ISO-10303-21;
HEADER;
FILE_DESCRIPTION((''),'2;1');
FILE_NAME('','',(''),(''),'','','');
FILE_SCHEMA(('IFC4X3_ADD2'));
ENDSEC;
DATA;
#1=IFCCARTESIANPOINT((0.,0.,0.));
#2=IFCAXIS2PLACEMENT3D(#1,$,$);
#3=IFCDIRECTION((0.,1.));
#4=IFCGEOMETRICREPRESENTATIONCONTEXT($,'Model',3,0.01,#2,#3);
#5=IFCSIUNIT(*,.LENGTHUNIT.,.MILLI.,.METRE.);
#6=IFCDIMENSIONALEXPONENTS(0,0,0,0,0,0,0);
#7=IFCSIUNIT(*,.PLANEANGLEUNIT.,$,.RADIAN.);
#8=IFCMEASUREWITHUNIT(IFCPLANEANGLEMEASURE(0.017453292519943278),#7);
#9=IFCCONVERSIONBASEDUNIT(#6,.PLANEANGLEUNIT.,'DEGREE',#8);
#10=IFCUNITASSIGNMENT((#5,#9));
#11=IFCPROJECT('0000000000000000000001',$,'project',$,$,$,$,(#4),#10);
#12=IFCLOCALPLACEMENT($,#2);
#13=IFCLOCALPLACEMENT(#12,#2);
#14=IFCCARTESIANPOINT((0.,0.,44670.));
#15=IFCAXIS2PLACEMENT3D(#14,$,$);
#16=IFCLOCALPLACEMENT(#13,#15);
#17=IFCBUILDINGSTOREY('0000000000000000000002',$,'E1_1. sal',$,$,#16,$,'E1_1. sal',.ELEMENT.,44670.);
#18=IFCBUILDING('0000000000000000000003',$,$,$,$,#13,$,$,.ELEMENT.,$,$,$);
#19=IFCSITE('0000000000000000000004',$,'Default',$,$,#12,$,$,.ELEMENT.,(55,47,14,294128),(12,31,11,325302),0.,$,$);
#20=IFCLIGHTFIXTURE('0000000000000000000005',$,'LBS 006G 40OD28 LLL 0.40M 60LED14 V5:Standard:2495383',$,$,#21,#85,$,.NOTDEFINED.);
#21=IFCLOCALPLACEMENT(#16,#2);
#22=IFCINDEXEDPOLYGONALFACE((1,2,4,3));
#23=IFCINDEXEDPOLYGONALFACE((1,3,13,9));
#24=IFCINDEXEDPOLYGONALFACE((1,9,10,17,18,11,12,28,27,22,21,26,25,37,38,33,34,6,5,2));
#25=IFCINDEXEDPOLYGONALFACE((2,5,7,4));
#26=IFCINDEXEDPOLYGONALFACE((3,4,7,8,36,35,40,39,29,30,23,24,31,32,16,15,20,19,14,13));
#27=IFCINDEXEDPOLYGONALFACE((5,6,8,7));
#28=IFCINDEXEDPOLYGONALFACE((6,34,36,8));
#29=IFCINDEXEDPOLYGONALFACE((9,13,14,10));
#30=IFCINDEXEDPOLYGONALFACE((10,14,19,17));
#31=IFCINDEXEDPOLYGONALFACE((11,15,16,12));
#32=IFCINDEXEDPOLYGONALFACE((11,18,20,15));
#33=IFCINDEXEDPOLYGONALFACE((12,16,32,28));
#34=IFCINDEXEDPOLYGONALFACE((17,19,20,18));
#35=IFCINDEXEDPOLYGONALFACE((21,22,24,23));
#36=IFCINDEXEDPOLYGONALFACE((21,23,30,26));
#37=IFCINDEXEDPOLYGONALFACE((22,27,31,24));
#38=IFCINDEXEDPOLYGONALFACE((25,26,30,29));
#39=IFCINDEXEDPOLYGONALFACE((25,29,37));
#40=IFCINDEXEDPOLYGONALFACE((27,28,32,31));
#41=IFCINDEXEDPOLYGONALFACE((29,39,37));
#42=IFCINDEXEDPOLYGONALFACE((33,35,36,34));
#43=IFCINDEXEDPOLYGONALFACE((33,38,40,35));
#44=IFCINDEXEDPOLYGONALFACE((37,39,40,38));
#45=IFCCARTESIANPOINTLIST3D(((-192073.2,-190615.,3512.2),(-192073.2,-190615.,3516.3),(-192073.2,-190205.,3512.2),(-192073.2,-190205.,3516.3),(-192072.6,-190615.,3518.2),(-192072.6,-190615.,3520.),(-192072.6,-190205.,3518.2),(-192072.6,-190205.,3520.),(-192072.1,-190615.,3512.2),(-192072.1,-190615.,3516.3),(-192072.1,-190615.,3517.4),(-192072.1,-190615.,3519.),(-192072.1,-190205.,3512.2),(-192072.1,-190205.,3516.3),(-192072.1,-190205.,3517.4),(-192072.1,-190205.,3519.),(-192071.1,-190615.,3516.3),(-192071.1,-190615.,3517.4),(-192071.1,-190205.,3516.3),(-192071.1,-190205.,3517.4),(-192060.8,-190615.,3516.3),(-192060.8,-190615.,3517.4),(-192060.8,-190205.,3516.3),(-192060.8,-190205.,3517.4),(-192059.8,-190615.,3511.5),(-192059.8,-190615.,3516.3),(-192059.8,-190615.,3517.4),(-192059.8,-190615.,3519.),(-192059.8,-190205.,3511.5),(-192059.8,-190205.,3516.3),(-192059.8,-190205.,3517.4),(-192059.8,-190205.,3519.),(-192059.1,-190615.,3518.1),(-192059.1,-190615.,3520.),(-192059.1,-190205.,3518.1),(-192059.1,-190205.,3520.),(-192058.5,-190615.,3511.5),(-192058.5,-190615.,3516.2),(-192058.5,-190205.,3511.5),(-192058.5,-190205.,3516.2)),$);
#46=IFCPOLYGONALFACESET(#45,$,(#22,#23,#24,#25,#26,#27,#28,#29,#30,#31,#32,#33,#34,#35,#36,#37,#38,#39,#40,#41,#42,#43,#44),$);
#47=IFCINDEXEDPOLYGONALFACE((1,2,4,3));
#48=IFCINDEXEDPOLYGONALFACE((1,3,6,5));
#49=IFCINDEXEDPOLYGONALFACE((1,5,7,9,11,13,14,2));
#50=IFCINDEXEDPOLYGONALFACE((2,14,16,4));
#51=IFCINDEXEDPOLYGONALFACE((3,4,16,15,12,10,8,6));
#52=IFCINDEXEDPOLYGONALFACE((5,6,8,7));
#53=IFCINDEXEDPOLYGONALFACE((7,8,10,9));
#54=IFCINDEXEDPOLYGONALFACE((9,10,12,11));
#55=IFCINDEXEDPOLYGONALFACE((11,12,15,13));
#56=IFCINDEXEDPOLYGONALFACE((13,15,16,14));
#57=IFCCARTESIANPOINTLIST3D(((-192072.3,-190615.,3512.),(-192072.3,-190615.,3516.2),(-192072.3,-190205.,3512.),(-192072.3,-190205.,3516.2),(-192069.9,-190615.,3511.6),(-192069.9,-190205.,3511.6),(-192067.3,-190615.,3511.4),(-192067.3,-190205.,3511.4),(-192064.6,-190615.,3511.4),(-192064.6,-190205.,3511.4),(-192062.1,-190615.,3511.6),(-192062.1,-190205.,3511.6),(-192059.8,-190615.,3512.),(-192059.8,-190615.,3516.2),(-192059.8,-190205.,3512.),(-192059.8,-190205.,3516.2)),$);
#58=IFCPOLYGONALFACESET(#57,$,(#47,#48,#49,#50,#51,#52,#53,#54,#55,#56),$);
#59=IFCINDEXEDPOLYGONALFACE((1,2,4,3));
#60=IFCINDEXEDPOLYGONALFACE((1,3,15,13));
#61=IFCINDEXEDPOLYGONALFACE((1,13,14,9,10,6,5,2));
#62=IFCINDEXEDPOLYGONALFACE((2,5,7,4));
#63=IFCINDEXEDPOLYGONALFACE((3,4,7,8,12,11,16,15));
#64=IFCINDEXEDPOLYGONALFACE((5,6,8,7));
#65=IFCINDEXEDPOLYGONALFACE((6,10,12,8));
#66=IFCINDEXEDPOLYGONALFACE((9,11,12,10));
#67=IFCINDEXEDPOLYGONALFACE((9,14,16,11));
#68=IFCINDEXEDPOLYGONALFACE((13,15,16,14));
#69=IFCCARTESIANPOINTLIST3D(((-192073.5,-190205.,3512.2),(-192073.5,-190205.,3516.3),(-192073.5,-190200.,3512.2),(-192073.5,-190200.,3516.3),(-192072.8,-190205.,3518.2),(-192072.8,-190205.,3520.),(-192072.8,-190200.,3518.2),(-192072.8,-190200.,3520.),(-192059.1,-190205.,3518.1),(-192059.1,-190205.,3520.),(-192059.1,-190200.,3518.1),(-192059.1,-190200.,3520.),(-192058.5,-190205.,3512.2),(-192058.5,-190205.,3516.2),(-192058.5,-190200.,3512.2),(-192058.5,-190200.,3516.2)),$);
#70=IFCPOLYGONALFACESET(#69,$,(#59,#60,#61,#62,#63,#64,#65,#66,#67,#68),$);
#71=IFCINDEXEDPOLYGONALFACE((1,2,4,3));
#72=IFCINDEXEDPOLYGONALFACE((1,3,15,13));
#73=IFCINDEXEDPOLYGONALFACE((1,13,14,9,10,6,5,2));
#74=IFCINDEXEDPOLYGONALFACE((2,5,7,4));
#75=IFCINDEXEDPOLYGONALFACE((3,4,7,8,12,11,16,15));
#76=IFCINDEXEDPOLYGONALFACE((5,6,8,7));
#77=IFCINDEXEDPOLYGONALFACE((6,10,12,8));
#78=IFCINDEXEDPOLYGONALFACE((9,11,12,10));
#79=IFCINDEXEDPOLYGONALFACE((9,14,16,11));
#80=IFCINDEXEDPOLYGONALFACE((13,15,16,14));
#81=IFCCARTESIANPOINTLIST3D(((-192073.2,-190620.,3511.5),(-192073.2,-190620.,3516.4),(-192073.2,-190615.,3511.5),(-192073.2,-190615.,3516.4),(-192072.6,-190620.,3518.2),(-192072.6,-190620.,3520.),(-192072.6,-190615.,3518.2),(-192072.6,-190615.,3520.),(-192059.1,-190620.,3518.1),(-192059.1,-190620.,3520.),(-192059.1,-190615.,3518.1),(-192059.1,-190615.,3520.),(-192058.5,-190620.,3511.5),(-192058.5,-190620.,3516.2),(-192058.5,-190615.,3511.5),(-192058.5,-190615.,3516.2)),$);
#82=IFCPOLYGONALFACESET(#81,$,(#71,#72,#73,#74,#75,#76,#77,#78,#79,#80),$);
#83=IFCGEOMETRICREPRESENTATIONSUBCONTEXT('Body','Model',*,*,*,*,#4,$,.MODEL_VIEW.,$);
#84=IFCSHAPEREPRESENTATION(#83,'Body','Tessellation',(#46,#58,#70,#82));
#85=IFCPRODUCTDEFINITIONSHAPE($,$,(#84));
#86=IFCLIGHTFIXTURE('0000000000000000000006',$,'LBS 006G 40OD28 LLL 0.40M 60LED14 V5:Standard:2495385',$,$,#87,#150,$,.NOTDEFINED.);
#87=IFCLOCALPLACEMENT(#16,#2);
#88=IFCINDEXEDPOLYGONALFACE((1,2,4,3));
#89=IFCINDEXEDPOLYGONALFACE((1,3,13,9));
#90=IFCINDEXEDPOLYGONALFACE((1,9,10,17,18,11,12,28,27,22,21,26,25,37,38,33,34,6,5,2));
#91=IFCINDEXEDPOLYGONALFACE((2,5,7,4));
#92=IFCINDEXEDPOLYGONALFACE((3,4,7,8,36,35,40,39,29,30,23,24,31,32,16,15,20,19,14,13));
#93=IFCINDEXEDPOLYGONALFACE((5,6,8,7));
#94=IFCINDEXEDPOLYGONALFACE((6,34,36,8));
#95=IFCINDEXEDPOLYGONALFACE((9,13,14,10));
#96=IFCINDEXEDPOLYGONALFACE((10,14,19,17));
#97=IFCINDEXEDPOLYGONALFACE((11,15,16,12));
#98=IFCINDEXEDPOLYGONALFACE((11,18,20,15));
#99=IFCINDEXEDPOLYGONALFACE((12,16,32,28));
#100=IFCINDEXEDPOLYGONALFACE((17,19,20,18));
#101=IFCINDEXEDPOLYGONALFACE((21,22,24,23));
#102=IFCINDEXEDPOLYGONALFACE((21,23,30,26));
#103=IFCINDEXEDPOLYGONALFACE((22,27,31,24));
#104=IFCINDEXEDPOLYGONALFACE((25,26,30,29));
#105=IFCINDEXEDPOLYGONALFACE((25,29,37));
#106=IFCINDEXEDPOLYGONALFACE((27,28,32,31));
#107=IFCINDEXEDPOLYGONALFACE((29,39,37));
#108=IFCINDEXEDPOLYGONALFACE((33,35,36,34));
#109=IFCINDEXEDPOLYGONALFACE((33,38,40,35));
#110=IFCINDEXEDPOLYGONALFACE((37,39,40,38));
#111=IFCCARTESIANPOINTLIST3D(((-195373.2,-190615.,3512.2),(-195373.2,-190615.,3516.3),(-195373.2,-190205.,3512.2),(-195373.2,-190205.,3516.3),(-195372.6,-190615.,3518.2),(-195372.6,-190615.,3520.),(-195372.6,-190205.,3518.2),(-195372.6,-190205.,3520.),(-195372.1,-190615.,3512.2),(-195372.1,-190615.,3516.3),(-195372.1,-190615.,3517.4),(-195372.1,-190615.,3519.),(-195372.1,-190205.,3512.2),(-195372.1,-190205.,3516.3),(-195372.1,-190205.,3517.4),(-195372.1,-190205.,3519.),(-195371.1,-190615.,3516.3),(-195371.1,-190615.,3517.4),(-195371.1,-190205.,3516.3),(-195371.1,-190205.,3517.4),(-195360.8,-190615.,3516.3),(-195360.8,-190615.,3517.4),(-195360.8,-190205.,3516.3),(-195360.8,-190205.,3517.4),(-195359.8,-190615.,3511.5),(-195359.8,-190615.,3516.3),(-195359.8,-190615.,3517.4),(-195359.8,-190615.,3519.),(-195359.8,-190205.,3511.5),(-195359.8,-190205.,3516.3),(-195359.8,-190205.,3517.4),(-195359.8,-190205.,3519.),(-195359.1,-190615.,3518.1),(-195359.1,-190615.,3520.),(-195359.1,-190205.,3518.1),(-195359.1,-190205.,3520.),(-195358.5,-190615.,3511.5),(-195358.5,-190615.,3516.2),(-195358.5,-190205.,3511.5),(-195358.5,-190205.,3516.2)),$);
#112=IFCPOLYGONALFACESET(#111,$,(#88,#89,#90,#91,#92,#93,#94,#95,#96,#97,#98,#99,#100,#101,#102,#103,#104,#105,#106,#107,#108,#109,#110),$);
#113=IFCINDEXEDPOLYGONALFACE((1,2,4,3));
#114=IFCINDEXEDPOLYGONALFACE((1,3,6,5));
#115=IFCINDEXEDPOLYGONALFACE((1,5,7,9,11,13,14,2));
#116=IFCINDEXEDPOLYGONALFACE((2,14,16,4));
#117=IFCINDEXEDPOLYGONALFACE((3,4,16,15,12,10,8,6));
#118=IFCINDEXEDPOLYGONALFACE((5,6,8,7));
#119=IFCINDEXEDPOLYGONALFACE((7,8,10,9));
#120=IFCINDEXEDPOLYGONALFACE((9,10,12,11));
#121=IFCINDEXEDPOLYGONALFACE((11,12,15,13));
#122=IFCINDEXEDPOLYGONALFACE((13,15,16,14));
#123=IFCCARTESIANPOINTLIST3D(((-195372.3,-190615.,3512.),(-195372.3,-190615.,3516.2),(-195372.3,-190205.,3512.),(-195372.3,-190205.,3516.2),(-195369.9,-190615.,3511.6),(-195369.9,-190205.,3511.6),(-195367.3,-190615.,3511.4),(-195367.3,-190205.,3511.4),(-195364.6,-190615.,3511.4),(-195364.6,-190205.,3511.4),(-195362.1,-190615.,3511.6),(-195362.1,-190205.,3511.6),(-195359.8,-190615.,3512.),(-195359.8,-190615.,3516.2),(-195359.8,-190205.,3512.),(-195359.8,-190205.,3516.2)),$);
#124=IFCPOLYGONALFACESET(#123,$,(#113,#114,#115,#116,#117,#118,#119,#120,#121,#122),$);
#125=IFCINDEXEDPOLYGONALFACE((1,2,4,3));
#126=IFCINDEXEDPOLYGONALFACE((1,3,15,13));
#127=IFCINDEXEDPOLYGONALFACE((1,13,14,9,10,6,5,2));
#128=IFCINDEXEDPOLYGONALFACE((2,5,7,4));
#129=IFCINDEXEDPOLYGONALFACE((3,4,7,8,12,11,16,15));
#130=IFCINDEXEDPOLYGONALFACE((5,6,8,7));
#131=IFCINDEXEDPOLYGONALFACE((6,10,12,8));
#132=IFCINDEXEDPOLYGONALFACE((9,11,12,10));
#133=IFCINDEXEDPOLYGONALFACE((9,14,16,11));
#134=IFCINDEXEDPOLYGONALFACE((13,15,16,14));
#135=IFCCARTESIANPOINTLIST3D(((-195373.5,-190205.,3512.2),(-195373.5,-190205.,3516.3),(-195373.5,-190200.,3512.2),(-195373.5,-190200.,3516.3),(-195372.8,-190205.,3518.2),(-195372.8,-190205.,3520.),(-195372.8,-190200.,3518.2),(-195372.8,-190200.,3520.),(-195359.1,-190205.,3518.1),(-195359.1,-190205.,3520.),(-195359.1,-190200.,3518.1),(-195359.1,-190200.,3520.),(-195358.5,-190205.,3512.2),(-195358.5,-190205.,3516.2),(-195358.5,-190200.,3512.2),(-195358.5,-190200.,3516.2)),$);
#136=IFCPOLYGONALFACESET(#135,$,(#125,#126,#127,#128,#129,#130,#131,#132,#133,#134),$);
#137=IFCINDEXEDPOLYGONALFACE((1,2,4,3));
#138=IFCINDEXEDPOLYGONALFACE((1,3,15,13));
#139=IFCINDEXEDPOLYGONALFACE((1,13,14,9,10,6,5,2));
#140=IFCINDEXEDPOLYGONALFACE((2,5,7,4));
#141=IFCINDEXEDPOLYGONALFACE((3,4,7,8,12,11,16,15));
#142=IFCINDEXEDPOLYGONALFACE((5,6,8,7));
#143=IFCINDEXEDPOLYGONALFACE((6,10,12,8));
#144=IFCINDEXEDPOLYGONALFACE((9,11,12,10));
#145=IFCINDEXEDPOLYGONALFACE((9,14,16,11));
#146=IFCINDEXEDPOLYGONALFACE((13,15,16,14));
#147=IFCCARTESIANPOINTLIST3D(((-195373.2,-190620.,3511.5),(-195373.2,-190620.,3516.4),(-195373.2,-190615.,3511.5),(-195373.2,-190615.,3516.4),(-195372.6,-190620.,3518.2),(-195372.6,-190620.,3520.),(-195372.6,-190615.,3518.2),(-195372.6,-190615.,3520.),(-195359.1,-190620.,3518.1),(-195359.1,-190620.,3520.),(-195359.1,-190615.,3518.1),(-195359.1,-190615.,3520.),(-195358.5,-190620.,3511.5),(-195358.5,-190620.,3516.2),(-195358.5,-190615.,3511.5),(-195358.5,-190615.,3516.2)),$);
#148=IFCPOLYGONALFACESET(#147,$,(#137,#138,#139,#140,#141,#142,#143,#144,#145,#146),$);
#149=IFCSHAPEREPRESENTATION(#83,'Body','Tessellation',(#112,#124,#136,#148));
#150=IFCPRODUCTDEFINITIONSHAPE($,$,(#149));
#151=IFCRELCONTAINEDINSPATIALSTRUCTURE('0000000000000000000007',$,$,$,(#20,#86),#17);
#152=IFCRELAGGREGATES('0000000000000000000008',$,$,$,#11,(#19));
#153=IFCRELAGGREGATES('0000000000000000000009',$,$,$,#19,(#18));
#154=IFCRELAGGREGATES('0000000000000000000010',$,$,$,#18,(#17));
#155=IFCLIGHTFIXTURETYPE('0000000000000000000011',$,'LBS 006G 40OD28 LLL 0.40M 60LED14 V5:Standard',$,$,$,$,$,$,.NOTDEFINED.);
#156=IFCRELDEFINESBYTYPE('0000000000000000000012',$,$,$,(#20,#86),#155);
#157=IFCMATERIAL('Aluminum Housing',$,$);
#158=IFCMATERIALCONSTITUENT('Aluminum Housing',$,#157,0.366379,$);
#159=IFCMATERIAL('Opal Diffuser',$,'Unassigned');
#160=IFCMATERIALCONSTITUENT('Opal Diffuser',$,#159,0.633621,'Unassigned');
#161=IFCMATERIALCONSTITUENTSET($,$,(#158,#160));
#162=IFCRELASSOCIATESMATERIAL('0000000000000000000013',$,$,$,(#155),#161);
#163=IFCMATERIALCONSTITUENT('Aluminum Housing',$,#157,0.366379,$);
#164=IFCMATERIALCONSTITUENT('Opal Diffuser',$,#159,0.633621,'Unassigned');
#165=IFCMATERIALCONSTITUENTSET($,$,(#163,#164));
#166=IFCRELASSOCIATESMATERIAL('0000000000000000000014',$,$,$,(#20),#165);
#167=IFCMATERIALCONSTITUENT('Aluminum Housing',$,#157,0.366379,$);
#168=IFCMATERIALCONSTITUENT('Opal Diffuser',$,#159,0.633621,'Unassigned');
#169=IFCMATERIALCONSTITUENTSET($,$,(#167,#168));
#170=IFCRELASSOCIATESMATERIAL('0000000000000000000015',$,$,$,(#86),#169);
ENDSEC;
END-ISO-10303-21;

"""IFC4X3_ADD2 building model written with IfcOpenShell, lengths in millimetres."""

from ifc_helpers import new_model, entity, si_unit, converted_unit, direction, frame, origin, place, context, subcontext, project, spatial, polyline, outline, extrude, source, transform, mapped, material, constituent, constituent_set, type_object, type_shapes, element, save


model = new_model("IFC4X3_ADD2")

# Units and contexts
model_context = context("Model", 3, precision=0.01, world=origin(), true_north=direction((0.0, 1.0)))
body_context = subcontext(model_context, "Body", "Model", "MODEL_VIEW")
ifc_project = project(units=[si_unit("LENGTHUNIT", "METRE", prefix="MILLI"), converted_unit("PLANEANGLEUNIT", "DEGREE", entity("IfcPlaneAngleMeasure", 0.017453292519943278), si_unit("PLANEANGLEUNIT", "RADIAN"), dimensions=[0, 0, 0, 0, 0, 0, 0])], contexts=[model_context])

# Site, building, storey
site_placement = place(None, origin())
site = spatial("IfcSite", under=ifc_project, at=site_placement, Name="Default", CompositionType="ELEMENT", RefLatitude=(55, 47, 14, 294128), RefLongitude=(12, 31, 11, 325302), RefElevation=0.0)
building_placement = place(site_placement, origin())
building = spatial("IfcBuilding", under=site, at=building_placement, CompositionType="ELEMENT")
storey_placement = place(building_placement, frame((0.0, 0.0, 44670.0)))
storey = spatial("IfcBuildingStorey", under=building, at=storey_placement, Name="E1_1. sal", LongName="E1_1. sal", CompositionType="ELEMENT", Elevation=44670.0)

# Light fixtures
ifc_material_1 = material(Name="Aluminum Housing")
ifc_constituent_1 = constituent(ifc_material_1, Name="Aluminum Housing", fraction=0.366379)
ifc_material_2 = material(Name="Opal Diffuser", Category="Unassigned")
ifc_constituent_2 = constituent(ifc_material_2, Name="Opal Diffuser", Category="Unassigned", fraction=0.633621)
ifc_constituent_set_1 = constituent_set(constituents=[ifc_constituent_1, ifc_constituent_2])
ifc_constituent_3 = constituent(ifc_material_1, Name="Aluminum Housing", fraction=0.366379)
ifc_constituent_4 = constituent(ifc_material_2, Name="Opal Diffuser", Category="Unassigned", fraction=0.633621)
ifc_constituent_set_2 = constituent_set(constituents=[ifc_constituent_3, ifc_constituent_4])
light_fixture_type = type_object("IfcLightFixtureType", Name="LBS 006G 40OD28 LLL 0.40M 60LED14 V5:Standard", PredefinedType="NOTDEFINED", material=ifc_constituent_set_2)
shared_shape_1 = source(origin(), body_context, "Body", "SweptSolid", [
    extrude(outline(polyline([(-5.0, -6.1), (-5.0, -7.4), (-0.3, -7.4), (1.7, -6.8), (3.5, -6.8), (3.5, 6.7), (1.8, 6.7), (-0.1, 7.3), (-4.2, 7.3), (-4.2, 6.2), (-0.1, 6.2), (-0.1, 5.2), (0.9, 5.2), (0.9, 6.2), (2.5, 6.2), (2.5, -6.1), (0.9, -6.1), (0.9, -5.1), (-0.1, -5.1), (-0.1, -6.1), (-5.0, -6.1)])), frame((-205.0, 0.1, 3.5), z_axis=(-1.0, 0.0, 0.0), x_axis=(0.0, 0.0, -1.0)), (0.0, 0.0, -1.0), 410.0),
    extrude(outline(polyline([(-0.8, -6.2), (3.4, -6.2), (3.4, 6.2), (-0.8, 6.2), (-1.2, 3.9), (-1.4, 1.4), (-1.4, -1.3), (-1.2, -3.9), (-0.8, -6.2)])), frame((-205.0, 0.0, 7.2), z_axis=(1.0, 0.0, 0.0), x_axis=(0.0, 0.0, -1.0)), (0.0, 0.0, 1.0), 410.0),
    extrude(outline(polyline([(-4.4, -7.5), (-0.3, -7.5), (1.5, -6.8), (3.3, -6.8), (3.3, 6.9), (1.5, 6.9), (-0.5, 7.4), (-4.4, 7.4), (-4.4, -7.5)])), frame((205.0, 0.0, 3.3), z_axis=(1.0, 0.0, 0.0), x_axis=(0.0, 0.0, -1.0)), (0.0, 0.0, 1.0), 5.0),
    extrude(outline(polyline([(-5.0, -7.4), (-0.1, -7.4), (1.7, -6.7), (3.5, -6.7), (3.5, 6.8), (1.6, 6.8), (-0.3, 7.3), (-5.0, 7.3), (-5.0, -7.4)])), frame((-210.0, 0.2, 3.5), z_axis=(1.0, 0.0, 0.0), x_axis=(0.0, 0.0, -1.0)), (0.0, 0.0, 1.0), 5.0),
])
type_shapes(light_fixture_type, [shared_shape_1])
light_fixture_1_placement = place(storey_placement, frame((-192066.0, -190410.0, 3520.0), z_axis=(0.0, 0.0, -1.0), x_axis=(0.0, 1.0, 0.0)))
element("IfcLightFixture", 1, at=light_fixture_1_placement, inside=storey, type_object=light_fixture_type, material=ifc_constituent_set_1, Name="LBS 006G 40OD28 LLL 0.40M 60LED14 V5:Standard:2495383", PredefinedType="NOTDEFINED", context=body_context, shape_type="MappedRepresentation", body=[
    mapped(shared_shape_1, transform((0.0, 0.0, 0.0), scale=1.0)),
])
ifc_constituent_5 = constituent(ifc_material_1, Name="Aluminum Housing", fraction=0.366379)
ifc_constituent_6 = constituent(ifc_material_2, Name="Opal Diffuser", Category="Unassigned", fraction=0.633621)
ifc_constituent_set_3 = constituent_set(constituents=[ifc_constituent_5, ifc_constituent_6])
light_fixture_2_placement = place(storey_placement, frame((-195366.0, -190410.0, 3520.0), z_axis=(0.0, 0.0, -1.0), x_axis=(0.0, 1.0, 0.0)))
element("IfcLightFixture", 2, at=light_fixture_2_placement, inside=storey, type_object=light_fixture_type, material=ifc_constituent_set_3, Name="LBS 006G 40OD28 LLL 0.40M 60LED14 V5:Standard:2495385", PredefinedType="NOTDEFINED", context=body_context, shape_type="MappedRepresentation", body=[
    mapped(shared_shape_1, transform((0.0, 0.0, 0.0), scale=1.0)),
])

save(model, "model.ifc")
